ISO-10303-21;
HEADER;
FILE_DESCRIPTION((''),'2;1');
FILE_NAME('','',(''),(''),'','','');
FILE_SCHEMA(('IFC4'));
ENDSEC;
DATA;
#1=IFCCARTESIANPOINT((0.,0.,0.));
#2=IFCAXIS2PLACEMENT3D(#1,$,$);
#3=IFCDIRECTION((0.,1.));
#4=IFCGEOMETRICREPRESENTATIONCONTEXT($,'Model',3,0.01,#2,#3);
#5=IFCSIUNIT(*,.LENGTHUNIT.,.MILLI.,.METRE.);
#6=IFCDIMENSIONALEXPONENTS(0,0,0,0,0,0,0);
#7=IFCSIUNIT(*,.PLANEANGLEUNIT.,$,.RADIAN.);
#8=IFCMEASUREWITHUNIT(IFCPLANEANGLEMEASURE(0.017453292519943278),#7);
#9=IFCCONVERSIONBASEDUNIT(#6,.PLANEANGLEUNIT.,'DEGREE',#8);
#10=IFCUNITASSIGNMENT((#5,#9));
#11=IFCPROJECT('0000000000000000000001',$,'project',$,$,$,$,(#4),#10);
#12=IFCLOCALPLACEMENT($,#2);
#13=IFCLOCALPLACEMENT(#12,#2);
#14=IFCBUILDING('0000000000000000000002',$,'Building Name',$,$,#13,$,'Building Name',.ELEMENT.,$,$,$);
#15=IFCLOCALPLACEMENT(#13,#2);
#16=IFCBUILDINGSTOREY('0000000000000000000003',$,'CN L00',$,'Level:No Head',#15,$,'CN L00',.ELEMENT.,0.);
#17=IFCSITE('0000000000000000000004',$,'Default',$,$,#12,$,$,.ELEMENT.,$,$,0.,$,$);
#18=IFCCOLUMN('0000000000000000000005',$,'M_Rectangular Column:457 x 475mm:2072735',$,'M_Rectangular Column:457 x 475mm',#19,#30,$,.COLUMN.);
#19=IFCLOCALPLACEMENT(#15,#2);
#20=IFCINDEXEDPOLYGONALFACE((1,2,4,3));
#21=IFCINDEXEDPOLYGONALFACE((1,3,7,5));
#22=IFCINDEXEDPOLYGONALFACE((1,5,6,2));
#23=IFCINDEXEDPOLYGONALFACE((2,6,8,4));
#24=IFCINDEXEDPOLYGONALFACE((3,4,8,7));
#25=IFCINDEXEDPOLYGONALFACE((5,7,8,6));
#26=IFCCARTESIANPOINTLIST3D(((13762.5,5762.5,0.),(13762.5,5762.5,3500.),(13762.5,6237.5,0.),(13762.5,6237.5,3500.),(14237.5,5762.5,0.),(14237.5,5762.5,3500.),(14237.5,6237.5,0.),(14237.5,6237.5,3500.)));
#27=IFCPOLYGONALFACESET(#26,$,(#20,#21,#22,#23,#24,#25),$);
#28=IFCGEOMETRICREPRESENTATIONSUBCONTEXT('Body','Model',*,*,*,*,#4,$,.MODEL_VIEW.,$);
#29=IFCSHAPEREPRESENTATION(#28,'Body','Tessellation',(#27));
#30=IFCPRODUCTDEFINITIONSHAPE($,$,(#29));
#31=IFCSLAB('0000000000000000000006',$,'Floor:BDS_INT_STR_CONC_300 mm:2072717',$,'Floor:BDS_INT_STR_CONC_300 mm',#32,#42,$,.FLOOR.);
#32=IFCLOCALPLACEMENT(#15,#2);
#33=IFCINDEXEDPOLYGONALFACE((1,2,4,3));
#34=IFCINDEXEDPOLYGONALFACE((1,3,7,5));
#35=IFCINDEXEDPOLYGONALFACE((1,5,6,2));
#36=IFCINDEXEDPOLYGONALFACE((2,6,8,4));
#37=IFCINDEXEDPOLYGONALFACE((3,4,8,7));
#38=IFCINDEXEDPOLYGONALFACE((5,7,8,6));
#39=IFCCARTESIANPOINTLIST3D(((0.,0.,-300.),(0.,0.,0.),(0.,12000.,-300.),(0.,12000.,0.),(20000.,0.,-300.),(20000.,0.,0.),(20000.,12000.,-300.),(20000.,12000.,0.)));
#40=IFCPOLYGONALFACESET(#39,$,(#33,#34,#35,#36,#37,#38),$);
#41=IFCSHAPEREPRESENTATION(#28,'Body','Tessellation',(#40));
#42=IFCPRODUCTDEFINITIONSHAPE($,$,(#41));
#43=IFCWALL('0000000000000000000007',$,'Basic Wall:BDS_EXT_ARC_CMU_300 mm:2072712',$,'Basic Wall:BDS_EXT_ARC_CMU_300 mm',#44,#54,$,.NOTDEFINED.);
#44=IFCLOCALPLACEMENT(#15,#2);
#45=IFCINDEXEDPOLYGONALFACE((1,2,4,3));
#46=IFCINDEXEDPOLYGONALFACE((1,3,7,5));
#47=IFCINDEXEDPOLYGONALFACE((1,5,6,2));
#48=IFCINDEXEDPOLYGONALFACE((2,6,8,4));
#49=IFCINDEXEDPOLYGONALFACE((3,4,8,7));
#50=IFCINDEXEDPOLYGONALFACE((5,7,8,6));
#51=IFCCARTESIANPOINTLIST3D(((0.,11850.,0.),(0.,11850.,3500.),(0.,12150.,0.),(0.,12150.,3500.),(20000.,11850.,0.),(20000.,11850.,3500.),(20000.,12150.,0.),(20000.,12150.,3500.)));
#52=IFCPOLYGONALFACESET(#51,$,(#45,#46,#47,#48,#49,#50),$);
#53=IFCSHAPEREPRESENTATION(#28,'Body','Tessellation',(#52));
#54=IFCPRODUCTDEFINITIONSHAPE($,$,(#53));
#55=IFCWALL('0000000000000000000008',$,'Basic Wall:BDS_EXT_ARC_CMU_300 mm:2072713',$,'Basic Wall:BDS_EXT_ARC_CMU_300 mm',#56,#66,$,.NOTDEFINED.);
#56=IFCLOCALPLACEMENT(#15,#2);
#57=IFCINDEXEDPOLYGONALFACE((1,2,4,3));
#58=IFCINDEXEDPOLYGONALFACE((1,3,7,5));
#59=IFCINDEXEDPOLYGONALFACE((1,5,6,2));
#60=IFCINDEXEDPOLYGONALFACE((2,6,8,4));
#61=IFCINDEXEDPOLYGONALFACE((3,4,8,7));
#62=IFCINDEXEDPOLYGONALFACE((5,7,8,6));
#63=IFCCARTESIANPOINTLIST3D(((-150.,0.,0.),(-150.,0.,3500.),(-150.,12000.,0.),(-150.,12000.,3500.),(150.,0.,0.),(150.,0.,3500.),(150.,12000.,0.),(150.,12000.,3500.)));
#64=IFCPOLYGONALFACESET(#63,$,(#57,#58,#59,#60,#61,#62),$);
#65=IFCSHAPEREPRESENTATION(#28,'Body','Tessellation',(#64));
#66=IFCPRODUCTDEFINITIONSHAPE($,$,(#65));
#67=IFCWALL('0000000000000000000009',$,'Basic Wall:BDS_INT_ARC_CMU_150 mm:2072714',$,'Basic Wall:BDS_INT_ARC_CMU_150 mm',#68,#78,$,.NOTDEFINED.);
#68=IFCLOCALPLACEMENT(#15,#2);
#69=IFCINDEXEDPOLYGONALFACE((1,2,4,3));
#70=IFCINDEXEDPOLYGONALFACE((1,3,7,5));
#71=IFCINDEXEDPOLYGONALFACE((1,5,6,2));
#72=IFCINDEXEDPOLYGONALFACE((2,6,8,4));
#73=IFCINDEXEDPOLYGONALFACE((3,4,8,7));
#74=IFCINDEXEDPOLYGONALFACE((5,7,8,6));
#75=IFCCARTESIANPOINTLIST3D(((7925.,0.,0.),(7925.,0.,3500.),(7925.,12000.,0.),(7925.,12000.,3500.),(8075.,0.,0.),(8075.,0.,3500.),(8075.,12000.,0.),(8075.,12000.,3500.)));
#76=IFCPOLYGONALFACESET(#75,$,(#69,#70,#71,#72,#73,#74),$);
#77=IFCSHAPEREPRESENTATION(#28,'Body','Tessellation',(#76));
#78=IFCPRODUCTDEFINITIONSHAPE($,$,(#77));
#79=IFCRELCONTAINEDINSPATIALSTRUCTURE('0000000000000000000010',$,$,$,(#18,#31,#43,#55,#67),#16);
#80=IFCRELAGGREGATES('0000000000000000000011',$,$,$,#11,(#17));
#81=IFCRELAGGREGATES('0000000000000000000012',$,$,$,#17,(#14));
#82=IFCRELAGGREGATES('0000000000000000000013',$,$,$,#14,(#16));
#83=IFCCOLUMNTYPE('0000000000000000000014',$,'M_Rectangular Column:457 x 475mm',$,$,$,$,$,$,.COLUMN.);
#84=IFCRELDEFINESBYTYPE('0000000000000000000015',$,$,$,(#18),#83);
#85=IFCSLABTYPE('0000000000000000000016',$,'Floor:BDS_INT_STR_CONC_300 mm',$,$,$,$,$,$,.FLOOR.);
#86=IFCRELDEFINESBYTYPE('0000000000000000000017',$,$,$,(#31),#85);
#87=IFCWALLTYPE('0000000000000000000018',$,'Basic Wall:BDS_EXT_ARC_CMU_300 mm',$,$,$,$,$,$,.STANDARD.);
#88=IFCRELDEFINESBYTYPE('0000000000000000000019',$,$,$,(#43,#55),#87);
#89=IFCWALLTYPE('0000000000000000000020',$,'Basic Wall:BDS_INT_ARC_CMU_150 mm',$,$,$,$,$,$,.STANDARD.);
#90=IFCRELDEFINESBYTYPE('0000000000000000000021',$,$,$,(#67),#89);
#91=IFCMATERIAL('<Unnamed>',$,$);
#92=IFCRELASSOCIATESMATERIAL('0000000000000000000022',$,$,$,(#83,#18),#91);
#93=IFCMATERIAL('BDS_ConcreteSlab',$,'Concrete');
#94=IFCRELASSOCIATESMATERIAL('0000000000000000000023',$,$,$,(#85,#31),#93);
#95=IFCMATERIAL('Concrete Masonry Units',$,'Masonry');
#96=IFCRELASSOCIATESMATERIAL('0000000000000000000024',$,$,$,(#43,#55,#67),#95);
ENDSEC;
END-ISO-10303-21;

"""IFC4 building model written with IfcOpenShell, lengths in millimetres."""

from ifc_helpers import new_model, entity, si_unit, converted_unit, direction, frame, origin, place, context, subcontext, project, spatial, indexed_curve, outline, extrude, source, transform, mapped, material, type_object, type_shapes, element, save


model = new_model("IFC4")

# Units and contexts
model_context = context("Model", 3, precision=0.01, world=origin(), true_north=direction((0.0, 1.0)))
body_context = subcontext(model_context, "Body", "Model", "MODEL_VIEW")
ifc_project = project(units=[si_unit("LENGTHUNIT", "METRE", prefix="MILLI"), converted_unit("PLANEANGLEUNIT", "DEGREE", entity("IfcPlaneAngleMeasure", 0.017453292519943278), si_unit("PLANEANGLEUNIT", "RADIAN"), dimensions=[0, 0, 0, 0, 0, 0, 0])], contexts=[model_context])

# Site, building, storey
site_placement = place(None, origin())
site = spatial("IfcSite", under=ifc_project, at=site_placement, Name="Default", CompositionType="ELEMENT", RefElevation=0.0)
building_placement = place(site_placement, origin())
building = spatial("IfcBuilding", under=site, at=building_placement, Name="Building Name", LongName="Building Name", CompositionType="ELEMENT")
storey_placement = place(building_placement, origin())
storey = spatial("IfcBuildingStorey", under=building, at=storey_placement, Name="CN L00", ObjectType="Level:No Head", LongName="CN L00", CompositionType="ELEMENT", Elevation=0.0)

# Column
ifc_material_1 = material(Name="<Unnamed>")
column_type = type_object("IfcColumnType", Name="M_Rectangular Column:457 x 475mm", PredefinedType="COLUMN", material=ifc_material_1)
shared_shape = source(origin(), body_context, "Body", "SweptSolid", [
    extrude(outline(indexed_curve([(-237.5, -237.5), (237.5, -237.5), (237.5, 237.5), (-237.5, 237.5), (-237.5, -237.5)], self_intersect=False)), frame((0.0, 0.0, 0.0), z_axis=(0.0, 0.0, 1.0), x_axis=(-1.0, 0.0, 0.0)), (0.0, 0.0, 1.0), 3500.0),
])
type_shapes(column_type, [shared_shape])
column_placement = place(storey_placement, frame((14000.0, 6000.0, 0.0)))
element("IfcColumn", 1, at=column_placement, inside=storey, type_object=column_type, material=ifc_material_1, Name="M_Rectangular Column:457 x 475mm:2072735", ObjectType="M_Rectangular Column:457 x 475mm", PredefinedType="COLUMN", context=body_context, shape_type="MappedRepresentation", body=[
    mapped(shared_shape, transform((0.0, 0.0, 0.0), scale=1.0)),
])

# Slab
ifc_material_2 = material(Name="BDS_ConcreteSlab", Category="Concrete")
slab_type = type_object("IfcSlabType", Name="Floor:BDS_INT_STR_CONC_300 mm", PredefinedType="FLOOR", material=ifc_material_2)
slab_placement = place(storey_placement, origin())
element("IfcSlab", 2, at=slab_placement, inside=storey, type_object=slab_type, material=ifc_material_2, Name="Floor:BDS_INT_STR_CONC_300 mm:2072717", ObjectType="Floor:BDS_INT_STR_CONC_300 mm", PredefinedType="FLOOR", context=body_context, shape_type="SweptSolid", body=[
    extrude(outline(indexed_curve([(-6000.0, -10000.0), (6000.0, -10000.0), (6000.0, 10000.0), (-6000.0, 10000.0), (-6000.0, -10000.0)], self_intersect=False)), frame((10000.0, 6000.0, 0.0), z_axis=(0.0, 0.0, -1.0), x_axis=(0.0, 1.0, 0.0)), (0.0, 0.0, 1.0), 300.0),
])

# Walls
ifc_material_3 = material(Name="Concrete Masonry Units", Category="Masonry")
wall_type_1 = type_object("IfcWallType", Name="Basic Wall:BDS_EXT_ARC_CMU_300 mm", PredefinedType="STANDARD")
wall_1_placement = place(storey_placement, frame((20000.0, 12000.0, 0.0), z_axis=(0.0, 0.0, 1.0), x_axis=(-1.0, 0.0, 0.0)))
element("IfcWall", 3, at=wall_1_placement, inside=storey, type_object=wall_type_1, material=ifc_material_3, Name="Basic Wall:BDS_EXT_ARC_CMU_300 mm:2072712", ObjectType="Basic Wall:BDS_EXT_ARC_CMU_300 mm", PredefinedType="NOTDEFINED", context=body_context, shape_type="SweptSolid", body=[
    extrude(outline(indexed_curve([(20000.0, 150.0), (0.0, 150.0), (0.0, -150.0), (20000.0, -150.0), (20000.0, 150.0)], self_intersect=False)), origin(), (0.0, 0.0, 1.0), 3500.0),
])
wall_2_placement = place(storey_placement, frame((0.0, 12000.0, 0.0), z_axis=(0.0, 0.0, 1.0), x_axis=(0.0, -1.0, 0.0)))
element("IfcWall", 4, at=wall_2_placement, inside=storey, type_object=wall_type_1, material=ifc_material_3, Name="Basic Wall:BDS_EXT_ARC_CMU_300 mm:2072713", ObjectType="Basic Wall:BDS_EXT_ARC_CMU_300 mm", PredefinedType="NOTDEFINED", context=body_context, shape_type="SweptSolid", body=[
    extrude(outline(indexed_curve([(12000.0, 150.0), (0.0, 150.0), (0.0, -150.0), (12000.0, -150.0), (12000.0, 150.0)], self_intersect=False)), origin(), (0.0, 0.0, 1.0), 3500.0),
])
wall_type_2 = type_object("IfcWallType", Name="Basic Wall:BDS_INT_ARC_CMU_150 mm", PredefinedType="STANDARD")
wall_3_placement = place(storey_placement, frame((8000.0, 0.0, 0.0), z_axis=(0.0, 0.0, 1.0), x_axis=(0.0, 1.0, 0.0)))
element("IfcWall", 5, at=wall_3_placement, inside=storey, type_object=wall_type_2, material=ifc_material_3, Name="Basic Wall:BDS_INT_ARC_CMU_150 mm:2072714", ObjectType="Basic Wall:BDS_INT_ARC_CMU_150 mm", PredefinedType="NOTDEFINED", context=body_context, shape_type="SweptSolid", body=[
    extrude(outline(indexed_curve([(12000.0, 75.0), (0.0, 75.0), (0.0, -75.0), (12000.0, -75.0), (12000.0, 75.0)], self_intersect=False)), origin(), (0.0, 0.0, 1.0), 3500.0),
])

save(model, "model.ifc")
